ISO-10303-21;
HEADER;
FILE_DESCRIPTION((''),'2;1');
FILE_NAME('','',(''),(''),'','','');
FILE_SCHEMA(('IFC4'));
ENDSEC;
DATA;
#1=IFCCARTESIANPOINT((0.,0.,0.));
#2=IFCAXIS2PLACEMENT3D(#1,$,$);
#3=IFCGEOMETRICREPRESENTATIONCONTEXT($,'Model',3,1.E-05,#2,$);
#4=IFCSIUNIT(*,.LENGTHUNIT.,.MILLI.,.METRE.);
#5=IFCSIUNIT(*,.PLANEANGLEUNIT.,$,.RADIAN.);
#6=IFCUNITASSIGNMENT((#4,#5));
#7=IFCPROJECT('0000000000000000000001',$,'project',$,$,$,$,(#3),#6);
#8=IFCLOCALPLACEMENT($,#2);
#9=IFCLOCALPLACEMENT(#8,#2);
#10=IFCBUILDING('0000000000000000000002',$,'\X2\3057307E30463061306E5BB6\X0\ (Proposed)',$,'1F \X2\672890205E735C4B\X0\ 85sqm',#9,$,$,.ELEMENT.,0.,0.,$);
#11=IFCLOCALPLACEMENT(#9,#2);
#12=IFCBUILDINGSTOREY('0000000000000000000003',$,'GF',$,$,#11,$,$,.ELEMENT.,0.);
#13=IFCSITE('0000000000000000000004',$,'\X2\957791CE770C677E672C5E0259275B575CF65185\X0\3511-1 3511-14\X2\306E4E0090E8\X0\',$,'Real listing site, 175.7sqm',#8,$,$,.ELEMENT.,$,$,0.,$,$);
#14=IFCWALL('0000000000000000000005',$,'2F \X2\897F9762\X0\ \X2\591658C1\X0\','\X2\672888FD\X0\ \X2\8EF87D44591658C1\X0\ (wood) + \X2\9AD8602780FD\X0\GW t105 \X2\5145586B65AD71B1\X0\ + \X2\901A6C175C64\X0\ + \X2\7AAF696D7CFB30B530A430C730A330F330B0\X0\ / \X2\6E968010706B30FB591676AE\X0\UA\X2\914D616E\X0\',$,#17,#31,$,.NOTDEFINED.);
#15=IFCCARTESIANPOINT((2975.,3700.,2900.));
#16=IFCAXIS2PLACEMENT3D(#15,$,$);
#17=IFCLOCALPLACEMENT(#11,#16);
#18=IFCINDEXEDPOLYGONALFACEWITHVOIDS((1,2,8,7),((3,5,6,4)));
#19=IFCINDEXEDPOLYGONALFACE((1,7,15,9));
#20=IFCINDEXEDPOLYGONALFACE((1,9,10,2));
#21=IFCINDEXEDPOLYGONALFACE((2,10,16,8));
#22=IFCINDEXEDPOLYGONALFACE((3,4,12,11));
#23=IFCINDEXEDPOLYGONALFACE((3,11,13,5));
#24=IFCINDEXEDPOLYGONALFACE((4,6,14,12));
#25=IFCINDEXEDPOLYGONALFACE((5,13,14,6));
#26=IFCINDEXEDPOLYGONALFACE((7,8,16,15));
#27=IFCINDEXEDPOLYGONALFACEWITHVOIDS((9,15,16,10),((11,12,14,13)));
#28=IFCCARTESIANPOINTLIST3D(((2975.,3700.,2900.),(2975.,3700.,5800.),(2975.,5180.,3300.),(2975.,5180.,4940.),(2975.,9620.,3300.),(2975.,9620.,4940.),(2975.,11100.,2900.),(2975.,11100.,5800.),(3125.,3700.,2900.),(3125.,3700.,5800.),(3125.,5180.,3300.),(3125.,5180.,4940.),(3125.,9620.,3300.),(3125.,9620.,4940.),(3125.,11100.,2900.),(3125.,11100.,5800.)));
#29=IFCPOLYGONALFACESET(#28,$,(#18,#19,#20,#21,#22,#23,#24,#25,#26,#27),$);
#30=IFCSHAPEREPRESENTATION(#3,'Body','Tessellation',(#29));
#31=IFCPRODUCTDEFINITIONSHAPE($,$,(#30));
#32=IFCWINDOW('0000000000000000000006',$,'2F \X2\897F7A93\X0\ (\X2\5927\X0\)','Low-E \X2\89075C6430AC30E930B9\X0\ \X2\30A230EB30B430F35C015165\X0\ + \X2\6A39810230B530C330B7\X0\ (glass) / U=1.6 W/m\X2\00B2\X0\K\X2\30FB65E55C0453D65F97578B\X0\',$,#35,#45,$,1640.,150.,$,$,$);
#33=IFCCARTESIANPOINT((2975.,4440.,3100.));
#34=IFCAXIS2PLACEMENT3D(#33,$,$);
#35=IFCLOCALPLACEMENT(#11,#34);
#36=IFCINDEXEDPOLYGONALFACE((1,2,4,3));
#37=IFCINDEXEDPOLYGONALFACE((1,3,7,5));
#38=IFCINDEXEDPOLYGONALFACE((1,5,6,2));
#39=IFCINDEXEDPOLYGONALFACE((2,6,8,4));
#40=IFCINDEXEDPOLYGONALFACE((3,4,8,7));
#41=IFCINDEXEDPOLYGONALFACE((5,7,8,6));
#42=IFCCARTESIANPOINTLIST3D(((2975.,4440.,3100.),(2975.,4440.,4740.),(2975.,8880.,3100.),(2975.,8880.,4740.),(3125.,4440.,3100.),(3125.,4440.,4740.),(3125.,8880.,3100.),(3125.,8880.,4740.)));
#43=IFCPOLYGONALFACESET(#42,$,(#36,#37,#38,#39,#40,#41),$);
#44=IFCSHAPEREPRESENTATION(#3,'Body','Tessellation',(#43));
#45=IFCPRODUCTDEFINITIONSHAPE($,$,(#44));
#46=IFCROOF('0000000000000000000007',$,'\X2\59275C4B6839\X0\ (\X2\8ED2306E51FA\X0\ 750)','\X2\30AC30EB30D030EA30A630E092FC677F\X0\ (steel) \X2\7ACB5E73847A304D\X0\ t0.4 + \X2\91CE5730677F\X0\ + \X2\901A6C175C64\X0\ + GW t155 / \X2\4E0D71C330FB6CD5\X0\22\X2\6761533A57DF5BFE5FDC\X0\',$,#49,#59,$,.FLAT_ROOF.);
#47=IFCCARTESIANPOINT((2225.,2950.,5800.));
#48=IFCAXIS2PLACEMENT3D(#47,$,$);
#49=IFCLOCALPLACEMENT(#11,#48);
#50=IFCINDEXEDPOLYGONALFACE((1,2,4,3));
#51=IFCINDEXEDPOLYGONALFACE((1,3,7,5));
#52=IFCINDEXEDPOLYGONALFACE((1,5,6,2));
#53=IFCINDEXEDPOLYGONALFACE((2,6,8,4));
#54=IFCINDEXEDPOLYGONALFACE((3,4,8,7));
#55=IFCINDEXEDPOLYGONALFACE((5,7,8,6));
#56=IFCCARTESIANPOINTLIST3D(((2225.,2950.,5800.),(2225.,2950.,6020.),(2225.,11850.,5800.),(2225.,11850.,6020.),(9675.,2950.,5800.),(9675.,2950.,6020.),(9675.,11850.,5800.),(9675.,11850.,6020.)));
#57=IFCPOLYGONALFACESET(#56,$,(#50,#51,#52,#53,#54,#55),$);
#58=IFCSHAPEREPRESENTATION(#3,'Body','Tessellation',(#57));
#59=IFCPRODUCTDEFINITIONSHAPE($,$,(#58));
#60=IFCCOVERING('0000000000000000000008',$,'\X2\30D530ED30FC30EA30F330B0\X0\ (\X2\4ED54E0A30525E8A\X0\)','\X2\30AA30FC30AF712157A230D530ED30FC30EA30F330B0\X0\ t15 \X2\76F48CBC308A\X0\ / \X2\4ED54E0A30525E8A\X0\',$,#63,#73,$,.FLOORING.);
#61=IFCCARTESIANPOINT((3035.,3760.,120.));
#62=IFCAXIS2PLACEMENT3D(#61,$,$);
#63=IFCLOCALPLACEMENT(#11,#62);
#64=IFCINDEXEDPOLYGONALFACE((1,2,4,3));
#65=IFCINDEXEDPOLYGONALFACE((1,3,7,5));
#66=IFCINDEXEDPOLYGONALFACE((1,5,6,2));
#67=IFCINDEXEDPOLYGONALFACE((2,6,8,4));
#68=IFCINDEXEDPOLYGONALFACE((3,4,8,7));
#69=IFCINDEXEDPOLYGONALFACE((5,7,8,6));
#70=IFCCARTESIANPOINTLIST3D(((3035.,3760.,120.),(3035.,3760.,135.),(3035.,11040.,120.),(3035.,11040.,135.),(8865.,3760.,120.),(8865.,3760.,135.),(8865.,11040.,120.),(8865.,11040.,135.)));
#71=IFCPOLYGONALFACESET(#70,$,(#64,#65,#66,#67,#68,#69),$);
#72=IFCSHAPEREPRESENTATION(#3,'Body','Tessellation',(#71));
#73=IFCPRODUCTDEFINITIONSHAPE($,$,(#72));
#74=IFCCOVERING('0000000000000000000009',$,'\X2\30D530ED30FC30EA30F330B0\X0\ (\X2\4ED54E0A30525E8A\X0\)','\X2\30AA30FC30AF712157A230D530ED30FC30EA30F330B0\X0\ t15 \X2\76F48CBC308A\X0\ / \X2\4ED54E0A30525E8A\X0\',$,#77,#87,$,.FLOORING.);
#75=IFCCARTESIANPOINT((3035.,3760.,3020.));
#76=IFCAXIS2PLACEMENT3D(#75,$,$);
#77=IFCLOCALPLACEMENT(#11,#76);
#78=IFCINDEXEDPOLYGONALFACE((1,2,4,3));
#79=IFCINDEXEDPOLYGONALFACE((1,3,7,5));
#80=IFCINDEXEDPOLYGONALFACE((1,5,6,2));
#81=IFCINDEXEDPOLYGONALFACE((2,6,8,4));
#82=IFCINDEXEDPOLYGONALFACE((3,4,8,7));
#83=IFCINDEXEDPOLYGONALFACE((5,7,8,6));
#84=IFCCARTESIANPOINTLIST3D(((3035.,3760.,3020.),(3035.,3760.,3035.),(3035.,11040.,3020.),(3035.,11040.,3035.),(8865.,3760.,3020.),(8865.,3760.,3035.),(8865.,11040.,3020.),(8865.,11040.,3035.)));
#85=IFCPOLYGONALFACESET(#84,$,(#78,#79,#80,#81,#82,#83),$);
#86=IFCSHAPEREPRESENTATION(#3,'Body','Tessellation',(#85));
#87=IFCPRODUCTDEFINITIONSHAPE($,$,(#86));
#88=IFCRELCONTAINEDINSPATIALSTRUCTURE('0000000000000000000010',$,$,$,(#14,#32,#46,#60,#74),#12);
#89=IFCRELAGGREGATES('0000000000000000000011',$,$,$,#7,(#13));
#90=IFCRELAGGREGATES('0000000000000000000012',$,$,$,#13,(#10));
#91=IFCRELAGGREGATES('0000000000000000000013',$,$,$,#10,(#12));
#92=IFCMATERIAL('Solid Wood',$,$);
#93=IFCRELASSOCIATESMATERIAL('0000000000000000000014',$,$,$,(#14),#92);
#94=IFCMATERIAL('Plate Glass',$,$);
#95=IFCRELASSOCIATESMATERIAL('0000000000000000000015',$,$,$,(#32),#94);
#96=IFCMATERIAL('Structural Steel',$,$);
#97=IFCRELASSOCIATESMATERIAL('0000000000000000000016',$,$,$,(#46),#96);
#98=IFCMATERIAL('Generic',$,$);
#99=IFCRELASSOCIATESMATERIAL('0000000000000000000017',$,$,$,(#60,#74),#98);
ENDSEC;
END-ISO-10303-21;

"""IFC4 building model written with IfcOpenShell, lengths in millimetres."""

from ifc_helpers import new_model, si_unit, frame, frame_2d, origin, place, context, project, spatial, rectangle, extrude, material, element, fill, save


model = new_model("IFC4")

# Units and contexts
model_context = context("Model", 3, precision=1e-05, world=origin())
ifc_project = project(units=[si_unit("LENGTHUNIT", "METRE", prefix="MILLI"), si_unit("PLANEANGLEUNIT", "RADIAN")], contexts=[model_context])

# Site, building, storey
site_placement = place(None, origin())
site = spatial("IfcSite", under=ifc_project, at=site_placement, Name="長野県松本市大字島内3511-1 3511-14の一部", ObjectType="Real listing site, 175.7sqm", CompositionType="ELEMENT", RefElevation=0.0)
building_placement = place(site_placement, origin())
building = spatial("IfcBuilding", under=site, at=building_placement, Name="しまうちの家 (Proposed)", ObjectType="1F 木造平屋 85sqm", CompositionType="ELEMENT", ElevationOfRefHeight=0.0, ElevationOfTerrain=0.0)
storey_placement = place(building_placement, origin())
storey = spatial("IfcBuildingStorey", under=building, at=storey_placement, Name="GF", CompositionType="ELEMENT", Elevation=0.0)

# Shared definitions
ifc_material_1 = material(Name="Solid Wood")
ifc_material_2 = material(Name="Generic")

# Shared definitions
ifc_material_3 = material(Name="Plate Glass")

# Wall, opening, window
wall_1_placement = place(storey_placement, frame((2975.0, 3700.0, 2900.0)))
wall_1 = element("IfcWall", 1, at=wall_1_placement, inside=storey, material=ifc_material_1, Name="2F 西面 外壁", Description="木製 軸組外壁 (wood) + 高性能GW t105 充填断熱 + 通気層 + 窯業系サイディング / 準耐火・外皮UA配慮", PredefinedType="NOTDEFINED", context=model_context, shape_type="SweptSolid", body=[
    extrude(rectangle(XDim=150.0, YDim=7400.0, at=frame_2d((75.0, 3700.0))), frame((2975.0, 3700.0, 2900.0)), (0.0, 0.0, 1.0), 2900.0),
])
opening_1_placement = place(storey_placement, frame((2975.0, 4440.0, 3100.0)))
opening_1 = element("IfcOpeningElement", 2, at=opening_1_placement, cuts=wall_1, PredefinedType="NOTDEFINED", context=model_context, shape_type="SweptSolid", body=[
    extrude(rectangle(XDim=150.0, YDim=4440.0, at=frame_2d((75.0, 2220.0))), frame((2975.0, 4440.0, 3100.0)), (0.0, 0.0, 1.0), 1640.0),
])
window_1_placement = place(storey_placement, frame((2975.0, 4440.0, 3100.0)))
window_1 = element("IfcWindow", 3, at=window_1_placement, inside=storey, material=ifc_material_3, Name="2F 西窓 (大)", Description="Low-E 複層ガラス アルゴン封入 + 樹脂サッシ (glass) / U=1.6 W/m²K・日射取得型", OverallHeight=1640.0, OverallWidth=150.0, context=model_context, shape_type="SweptSolid", body=[
    extrude(rectangle(XDim=150.0, YDim=4440.0, at=frame_2d((75.0, 2220.0))), frame((2975.0, 4440.0, 3100.0)), (0.0, 0.0, 1.0), 1640.0),
])
fill(opening_1, window_1)

# Roof
ifc_material_4 = material(Name="Structural Steel")
roof_placement = place(storey_placement, frame((2225.0, 2950.0, 5800.0)))
element("IfcRoof", 4, at=roof_placement, inside=storey, material=ifc_material_4, Name="大屋根 (軒の出 750)", Description="ガルバリウム鋼板 (steel) 立平葺き t0.4 + 野地板 + 通気層 + GW t155 / 不燃・法22条区域対応", PredefinedType="FLAT_ROOF", context=model_context, shape_type="SweptSolid", body=[
    extrude(rectangle(XDim=7450.0, YDim=8900.0, at=frame_2d((3725.0, 4450.0))), frame((2225.0, 2950.0, 5800.0)), (0.0, 0.0, 1.0), 220.0),
])

# Coverings
covering_1_placement = place(storey_placement, frame((3035.0, 3760.0, 120.0)))
element("IfcCovering", 5, at=covering_1_placement, inside=storey, material=ifc_material_2, Name="フローリング (仕上げ床)", Description="オーク無垢フローリング t15 直貼り / 仕上げ床", PredefinedType="FLOORING", context=model_context, shape_type="SweptSolid", body=[
    extrude(rectangle(XDim=5830.0, YDim=7280.0, at=frame_2d((2915.0, 3640.0))), frame((3035.0, 3760.0, 120.0)), (0.0, 0.0, 1.0), 15.0),
])
covering_2_placement = place(storey_placement, frame((3035.0, 3760.0, 3020.0)))
element("IfcCovering", 6, at=covering_2_placement, inside=storey, material=ifc_material_2, Name="フローリング (仕上げ床)", Description="オーク無垢フローリング t15 直貼り / 仕上げ床", PredefinedType="FLOORING", context=model_context, shape_type="SweptSolid", body=[
    extrude(rectangle(XDim=5830.0, YDim=7280.0, at=frame_2d((2915.0, 3640.0))), frame((3035.0, 3760.0, 3020.0)), (0.0, 0.0, 1.0), 15.0),
])

save(model, "model.ifc")
